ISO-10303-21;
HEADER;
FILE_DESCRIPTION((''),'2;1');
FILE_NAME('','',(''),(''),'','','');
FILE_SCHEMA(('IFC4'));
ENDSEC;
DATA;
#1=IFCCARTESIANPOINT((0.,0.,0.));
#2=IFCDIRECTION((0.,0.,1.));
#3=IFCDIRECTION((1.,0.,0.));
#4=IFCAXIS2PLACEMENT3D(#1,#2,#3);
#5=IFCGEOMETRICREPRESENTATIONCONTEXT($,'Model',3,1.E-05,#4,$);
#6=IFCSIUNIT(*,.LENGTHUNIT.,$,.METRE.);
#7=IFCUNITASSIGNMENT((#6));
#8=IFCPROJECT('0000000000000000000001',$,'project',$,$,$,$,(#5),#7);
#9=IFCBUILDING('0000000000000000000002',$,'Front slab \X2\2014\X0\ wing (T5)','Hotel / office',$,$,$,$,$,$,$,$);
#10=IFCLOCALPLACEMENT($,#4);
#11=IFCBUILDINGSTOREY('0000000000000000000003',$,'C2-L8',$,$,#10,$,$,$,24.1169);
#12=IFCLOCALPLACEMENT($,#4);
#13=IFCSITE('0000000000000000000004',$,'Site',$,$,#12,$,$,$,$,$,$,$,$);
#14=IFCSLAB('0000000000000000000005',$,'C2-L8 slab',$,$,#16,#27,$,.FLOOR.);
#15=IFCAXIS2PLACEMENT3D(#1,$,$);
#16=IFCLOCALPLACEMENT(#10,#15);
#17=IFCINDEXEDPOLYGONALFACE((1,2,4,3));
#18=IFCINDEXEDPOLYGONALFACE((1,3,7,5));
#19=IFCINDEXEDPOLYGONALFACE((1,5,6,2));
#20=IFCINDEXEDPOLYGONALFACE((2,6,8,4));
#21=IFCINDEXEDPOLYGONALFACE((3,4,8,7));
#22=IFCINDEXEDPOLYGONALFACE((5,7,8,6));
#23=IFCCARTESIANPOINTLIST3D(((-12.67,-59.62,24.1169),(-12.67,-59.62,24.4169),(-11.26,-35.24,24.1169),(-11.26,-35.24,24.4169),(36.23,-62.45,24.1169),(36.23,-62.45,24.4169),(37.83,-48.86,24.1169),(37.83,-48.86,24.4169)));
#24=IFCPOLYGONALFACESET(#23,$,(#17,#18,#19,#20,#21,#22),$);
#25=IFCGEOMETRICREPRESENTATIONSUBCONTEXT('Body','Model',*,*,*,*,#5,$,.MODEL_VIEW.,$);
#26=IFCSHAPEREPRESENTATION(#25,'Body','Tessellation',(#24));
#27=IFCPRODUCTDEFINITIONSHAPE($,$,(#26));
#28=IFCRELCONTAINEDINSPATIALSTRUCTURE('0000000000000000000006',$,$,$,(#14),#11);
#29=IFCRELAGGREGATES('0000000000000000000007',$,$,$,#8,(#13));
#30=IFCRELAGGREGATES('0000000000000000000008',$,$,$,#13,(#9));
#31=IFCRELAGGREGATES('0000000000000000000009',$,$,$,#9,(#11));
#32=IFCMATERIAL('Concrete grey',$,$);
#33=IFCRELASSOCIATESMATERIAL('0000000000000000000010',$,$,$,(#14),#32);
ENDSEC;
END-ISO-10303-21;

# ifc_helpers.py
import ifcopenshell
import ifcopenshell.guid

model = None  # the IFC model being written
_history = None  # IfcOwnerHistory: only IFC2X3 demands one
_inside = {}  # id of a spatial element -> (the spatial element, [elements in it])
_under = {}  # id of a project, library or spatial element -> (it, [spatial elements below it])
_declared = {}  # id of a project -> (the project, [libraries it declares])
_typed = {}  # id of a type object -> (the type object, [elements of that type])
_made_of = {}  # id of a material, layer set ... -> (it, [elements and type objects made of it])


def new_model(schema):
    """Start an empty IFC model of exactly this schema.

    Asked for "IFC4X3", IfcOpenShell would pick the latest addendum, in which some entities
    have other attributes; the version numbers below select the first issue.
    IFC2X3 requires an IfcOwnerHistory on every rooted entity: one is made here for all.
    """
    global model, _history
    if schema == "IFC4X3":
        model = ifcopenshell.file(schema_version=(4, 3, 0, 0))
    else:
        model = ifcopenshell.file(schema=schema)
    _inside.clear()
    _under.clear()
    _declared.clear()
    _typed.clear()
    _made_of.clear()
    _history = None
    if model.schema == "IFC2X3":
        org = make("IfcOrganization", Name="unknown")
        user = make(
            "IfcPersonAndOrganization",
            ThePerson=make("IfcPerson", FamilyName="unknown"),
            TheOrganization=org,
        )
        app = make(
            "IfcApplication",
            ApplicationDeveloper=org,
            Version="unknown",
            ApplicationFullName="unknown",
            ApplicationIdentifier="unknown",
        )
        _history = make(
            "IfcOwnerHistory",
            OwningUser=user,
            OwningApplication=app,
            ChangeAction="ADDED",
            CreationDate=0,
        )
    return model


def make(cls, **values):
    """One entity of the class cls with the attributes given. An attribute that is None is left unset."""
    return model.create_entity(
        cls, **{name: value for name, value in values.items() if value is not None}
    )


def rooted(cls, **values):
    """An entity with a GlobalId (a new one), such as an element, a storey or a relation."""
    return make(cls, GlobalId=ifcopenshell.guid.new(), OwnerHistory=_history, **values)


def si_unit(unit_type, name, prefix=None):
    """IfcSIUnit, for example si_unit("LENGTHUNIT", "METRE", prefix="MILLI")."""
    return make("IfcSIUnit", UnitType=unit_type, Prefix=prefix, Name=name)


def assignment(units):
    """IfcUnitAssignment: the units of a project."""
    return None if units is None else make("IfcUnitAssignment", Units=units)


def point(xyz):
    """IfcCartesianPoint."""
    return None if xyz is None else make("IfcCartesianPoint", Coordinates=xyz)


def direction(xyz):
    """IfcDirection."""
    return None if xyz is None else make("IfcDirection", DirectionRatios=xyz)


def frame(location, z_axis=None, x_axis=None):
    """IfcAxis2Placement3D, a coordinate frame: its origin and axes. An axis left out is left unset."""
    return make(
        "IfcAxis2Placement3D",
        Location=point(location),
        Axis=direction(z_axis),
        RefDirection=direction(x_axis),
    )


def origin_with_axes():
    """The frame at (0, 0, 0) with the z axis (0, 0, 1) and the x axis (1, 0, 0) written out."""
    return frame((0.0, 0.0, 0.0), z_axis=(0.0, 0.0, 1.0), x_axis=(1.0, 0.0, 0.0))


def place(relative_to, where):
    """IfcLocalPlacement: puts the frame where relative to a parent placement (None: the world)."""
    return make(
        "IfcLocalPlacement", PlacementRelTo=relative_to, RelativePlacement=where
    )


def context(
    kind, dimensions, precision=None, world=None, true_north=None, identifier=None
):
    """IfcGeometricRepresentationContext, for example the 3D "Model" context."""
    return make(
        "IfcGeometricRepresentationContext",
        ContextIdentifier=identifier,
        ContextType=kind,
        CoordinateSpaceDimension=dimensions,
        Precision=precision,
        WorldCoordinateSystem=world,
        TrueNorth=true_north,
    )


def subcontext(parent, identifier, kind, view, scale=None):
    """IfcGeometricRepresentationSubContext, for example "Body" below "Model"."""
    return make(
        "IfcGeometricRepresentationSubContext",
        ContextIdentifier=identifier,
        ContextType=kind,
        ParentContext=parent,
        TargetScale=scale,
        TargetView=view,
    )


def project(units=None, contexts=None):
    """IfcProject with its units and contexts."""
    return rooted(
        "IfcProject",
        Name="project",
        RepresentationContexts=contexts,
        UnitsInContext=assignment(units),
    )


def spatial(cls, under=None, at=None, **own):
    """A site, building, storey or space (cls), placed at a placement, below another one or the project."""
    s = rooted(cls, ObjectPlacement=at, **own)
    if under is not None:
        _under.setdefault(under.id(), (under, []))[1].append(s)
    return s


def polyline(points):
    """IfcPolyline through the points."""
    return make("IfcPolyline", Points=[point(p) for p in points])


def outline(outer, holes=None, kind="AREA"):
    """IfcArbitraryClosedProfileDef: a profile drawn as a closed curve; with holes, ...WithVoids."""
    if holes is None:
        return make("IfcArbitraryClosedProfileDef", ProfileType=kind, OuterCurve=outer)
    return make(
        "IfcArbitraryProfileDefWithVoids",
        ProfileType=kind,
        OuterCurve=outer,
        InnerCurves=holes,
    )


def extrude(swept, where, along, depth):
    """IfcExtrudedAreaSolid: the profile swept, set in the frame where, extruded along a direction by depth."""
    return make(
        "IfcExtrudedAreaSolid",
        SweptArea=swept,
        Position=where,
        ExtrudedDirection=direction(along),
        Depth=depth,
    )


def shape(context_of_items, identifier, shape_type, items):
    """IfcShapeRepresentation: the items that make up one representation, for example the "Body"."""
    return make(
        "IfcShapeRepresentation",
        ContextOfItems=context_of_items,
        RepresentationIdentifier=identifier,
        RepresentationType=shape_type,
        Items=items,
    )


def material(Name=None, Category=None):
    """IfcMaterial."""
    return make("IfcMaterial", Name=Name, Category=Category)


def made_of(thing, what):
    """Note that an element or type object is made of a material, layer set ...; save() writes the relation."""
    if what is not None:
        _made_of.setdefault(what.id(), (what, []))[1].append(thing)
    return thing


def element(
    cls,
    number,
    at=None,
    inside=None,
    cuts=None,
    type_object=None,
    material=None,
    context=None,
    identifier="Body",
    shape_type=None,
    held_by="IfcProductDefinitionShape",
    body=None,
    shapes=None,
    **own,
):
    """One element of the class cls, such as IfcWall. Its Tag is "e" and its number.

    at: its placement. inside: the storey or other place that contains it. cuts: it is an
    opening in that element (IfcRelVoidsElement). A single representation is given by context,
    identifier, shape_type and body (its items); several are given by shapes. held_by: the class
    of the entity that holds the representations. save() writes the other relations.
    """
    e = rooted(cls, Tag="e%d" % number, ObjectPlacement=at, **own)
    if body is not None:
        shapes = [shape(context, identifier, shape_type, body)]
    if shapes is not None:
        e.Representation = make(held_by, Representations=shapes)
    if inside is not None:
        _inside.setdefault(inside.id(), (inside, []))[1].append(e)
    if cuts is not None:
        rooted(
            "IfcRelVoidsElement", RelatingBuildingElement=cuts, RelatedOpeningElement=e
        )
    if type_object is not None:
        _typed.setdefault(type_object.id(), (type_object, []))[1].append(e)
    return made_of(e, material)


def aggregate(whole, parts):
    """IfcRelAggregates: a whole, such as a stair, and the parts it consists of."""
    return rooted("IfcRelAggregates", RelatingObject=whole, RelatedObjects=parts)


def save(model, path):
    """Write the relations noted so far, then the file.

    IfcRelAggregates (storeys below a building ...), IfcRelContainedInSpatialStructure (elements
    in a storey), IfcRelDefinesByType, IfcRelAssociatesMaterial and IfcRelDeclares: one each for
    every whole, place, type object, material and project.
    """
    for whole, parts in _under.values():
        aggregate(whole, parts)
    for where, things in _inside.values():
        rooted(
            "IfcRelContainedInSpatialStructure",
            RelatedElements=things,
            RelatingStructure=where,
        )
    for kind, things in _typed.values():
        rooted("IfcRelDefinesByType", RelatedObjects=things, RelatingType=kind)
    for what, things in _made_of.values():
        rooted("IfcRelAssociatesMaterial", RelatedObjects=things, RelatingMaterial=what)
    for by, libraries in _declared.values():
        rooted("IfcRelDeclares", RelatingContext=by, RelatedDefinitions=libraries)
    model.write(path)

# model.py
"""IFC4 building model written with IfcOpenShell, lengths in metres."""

from ifc_helpers import new_model, si_unit, frame, origin_with_axes, place, context, subcontext, project, spatial, polyline, outline, extrude, material, element, save


model = new_model("IFC4")

# Units and contexts
model_context = context("Model", 3, precision=1e-05, world=origin_with_axes())
body_context = subcontext(model_context, "Body", "Model", "MODEL_VIEW")
ifc_project = project(units=[si_unit("LENGTHUNIT", "METRE")], contexts=[model_context])

# Site, building, storey
site_placement = place(None, origin_with_axes())
site = spatial("IfcSite", under=ifc_project, at=site_placement, Name="Site")
building = spatial("IfcBuilding", under=site, Name="Front slab — wing (T5)", Description="Hotel / office")
storey_placement = place(None, origin_with_axes())
storey = spatial("IfcBuildingStorey", under=building, at=storey_placement, Name="C2-L8", Elevation=24.1169)

# Slab
ifc_material_1 = material(Name="Concrete grey")
slab_placement = place(storey_placement, origin_with_axes())
element("IfcSlab", 1, at=slab_placement, inside=storey, material=ifc_material_1, Name="C2-L8 slab", PredefinedType="FLOOR", context=body_context, shape_type="SweptSolid", body=[
    extrude(outline(polyline([(-11.26, -35.24), (-12.67, -59.62), (36.23, -62.45), (37.83, -48.86), (-11.26, -35.24)])), frame((0.0, 0.0, 24.1169), z_axis=(0.0, 0.0, 1.0), x_axis=(1.0, 0.0, 0.0)), (0.0, 0.0, 1.0), 0.3),
])

save(model, "model.ifc")
